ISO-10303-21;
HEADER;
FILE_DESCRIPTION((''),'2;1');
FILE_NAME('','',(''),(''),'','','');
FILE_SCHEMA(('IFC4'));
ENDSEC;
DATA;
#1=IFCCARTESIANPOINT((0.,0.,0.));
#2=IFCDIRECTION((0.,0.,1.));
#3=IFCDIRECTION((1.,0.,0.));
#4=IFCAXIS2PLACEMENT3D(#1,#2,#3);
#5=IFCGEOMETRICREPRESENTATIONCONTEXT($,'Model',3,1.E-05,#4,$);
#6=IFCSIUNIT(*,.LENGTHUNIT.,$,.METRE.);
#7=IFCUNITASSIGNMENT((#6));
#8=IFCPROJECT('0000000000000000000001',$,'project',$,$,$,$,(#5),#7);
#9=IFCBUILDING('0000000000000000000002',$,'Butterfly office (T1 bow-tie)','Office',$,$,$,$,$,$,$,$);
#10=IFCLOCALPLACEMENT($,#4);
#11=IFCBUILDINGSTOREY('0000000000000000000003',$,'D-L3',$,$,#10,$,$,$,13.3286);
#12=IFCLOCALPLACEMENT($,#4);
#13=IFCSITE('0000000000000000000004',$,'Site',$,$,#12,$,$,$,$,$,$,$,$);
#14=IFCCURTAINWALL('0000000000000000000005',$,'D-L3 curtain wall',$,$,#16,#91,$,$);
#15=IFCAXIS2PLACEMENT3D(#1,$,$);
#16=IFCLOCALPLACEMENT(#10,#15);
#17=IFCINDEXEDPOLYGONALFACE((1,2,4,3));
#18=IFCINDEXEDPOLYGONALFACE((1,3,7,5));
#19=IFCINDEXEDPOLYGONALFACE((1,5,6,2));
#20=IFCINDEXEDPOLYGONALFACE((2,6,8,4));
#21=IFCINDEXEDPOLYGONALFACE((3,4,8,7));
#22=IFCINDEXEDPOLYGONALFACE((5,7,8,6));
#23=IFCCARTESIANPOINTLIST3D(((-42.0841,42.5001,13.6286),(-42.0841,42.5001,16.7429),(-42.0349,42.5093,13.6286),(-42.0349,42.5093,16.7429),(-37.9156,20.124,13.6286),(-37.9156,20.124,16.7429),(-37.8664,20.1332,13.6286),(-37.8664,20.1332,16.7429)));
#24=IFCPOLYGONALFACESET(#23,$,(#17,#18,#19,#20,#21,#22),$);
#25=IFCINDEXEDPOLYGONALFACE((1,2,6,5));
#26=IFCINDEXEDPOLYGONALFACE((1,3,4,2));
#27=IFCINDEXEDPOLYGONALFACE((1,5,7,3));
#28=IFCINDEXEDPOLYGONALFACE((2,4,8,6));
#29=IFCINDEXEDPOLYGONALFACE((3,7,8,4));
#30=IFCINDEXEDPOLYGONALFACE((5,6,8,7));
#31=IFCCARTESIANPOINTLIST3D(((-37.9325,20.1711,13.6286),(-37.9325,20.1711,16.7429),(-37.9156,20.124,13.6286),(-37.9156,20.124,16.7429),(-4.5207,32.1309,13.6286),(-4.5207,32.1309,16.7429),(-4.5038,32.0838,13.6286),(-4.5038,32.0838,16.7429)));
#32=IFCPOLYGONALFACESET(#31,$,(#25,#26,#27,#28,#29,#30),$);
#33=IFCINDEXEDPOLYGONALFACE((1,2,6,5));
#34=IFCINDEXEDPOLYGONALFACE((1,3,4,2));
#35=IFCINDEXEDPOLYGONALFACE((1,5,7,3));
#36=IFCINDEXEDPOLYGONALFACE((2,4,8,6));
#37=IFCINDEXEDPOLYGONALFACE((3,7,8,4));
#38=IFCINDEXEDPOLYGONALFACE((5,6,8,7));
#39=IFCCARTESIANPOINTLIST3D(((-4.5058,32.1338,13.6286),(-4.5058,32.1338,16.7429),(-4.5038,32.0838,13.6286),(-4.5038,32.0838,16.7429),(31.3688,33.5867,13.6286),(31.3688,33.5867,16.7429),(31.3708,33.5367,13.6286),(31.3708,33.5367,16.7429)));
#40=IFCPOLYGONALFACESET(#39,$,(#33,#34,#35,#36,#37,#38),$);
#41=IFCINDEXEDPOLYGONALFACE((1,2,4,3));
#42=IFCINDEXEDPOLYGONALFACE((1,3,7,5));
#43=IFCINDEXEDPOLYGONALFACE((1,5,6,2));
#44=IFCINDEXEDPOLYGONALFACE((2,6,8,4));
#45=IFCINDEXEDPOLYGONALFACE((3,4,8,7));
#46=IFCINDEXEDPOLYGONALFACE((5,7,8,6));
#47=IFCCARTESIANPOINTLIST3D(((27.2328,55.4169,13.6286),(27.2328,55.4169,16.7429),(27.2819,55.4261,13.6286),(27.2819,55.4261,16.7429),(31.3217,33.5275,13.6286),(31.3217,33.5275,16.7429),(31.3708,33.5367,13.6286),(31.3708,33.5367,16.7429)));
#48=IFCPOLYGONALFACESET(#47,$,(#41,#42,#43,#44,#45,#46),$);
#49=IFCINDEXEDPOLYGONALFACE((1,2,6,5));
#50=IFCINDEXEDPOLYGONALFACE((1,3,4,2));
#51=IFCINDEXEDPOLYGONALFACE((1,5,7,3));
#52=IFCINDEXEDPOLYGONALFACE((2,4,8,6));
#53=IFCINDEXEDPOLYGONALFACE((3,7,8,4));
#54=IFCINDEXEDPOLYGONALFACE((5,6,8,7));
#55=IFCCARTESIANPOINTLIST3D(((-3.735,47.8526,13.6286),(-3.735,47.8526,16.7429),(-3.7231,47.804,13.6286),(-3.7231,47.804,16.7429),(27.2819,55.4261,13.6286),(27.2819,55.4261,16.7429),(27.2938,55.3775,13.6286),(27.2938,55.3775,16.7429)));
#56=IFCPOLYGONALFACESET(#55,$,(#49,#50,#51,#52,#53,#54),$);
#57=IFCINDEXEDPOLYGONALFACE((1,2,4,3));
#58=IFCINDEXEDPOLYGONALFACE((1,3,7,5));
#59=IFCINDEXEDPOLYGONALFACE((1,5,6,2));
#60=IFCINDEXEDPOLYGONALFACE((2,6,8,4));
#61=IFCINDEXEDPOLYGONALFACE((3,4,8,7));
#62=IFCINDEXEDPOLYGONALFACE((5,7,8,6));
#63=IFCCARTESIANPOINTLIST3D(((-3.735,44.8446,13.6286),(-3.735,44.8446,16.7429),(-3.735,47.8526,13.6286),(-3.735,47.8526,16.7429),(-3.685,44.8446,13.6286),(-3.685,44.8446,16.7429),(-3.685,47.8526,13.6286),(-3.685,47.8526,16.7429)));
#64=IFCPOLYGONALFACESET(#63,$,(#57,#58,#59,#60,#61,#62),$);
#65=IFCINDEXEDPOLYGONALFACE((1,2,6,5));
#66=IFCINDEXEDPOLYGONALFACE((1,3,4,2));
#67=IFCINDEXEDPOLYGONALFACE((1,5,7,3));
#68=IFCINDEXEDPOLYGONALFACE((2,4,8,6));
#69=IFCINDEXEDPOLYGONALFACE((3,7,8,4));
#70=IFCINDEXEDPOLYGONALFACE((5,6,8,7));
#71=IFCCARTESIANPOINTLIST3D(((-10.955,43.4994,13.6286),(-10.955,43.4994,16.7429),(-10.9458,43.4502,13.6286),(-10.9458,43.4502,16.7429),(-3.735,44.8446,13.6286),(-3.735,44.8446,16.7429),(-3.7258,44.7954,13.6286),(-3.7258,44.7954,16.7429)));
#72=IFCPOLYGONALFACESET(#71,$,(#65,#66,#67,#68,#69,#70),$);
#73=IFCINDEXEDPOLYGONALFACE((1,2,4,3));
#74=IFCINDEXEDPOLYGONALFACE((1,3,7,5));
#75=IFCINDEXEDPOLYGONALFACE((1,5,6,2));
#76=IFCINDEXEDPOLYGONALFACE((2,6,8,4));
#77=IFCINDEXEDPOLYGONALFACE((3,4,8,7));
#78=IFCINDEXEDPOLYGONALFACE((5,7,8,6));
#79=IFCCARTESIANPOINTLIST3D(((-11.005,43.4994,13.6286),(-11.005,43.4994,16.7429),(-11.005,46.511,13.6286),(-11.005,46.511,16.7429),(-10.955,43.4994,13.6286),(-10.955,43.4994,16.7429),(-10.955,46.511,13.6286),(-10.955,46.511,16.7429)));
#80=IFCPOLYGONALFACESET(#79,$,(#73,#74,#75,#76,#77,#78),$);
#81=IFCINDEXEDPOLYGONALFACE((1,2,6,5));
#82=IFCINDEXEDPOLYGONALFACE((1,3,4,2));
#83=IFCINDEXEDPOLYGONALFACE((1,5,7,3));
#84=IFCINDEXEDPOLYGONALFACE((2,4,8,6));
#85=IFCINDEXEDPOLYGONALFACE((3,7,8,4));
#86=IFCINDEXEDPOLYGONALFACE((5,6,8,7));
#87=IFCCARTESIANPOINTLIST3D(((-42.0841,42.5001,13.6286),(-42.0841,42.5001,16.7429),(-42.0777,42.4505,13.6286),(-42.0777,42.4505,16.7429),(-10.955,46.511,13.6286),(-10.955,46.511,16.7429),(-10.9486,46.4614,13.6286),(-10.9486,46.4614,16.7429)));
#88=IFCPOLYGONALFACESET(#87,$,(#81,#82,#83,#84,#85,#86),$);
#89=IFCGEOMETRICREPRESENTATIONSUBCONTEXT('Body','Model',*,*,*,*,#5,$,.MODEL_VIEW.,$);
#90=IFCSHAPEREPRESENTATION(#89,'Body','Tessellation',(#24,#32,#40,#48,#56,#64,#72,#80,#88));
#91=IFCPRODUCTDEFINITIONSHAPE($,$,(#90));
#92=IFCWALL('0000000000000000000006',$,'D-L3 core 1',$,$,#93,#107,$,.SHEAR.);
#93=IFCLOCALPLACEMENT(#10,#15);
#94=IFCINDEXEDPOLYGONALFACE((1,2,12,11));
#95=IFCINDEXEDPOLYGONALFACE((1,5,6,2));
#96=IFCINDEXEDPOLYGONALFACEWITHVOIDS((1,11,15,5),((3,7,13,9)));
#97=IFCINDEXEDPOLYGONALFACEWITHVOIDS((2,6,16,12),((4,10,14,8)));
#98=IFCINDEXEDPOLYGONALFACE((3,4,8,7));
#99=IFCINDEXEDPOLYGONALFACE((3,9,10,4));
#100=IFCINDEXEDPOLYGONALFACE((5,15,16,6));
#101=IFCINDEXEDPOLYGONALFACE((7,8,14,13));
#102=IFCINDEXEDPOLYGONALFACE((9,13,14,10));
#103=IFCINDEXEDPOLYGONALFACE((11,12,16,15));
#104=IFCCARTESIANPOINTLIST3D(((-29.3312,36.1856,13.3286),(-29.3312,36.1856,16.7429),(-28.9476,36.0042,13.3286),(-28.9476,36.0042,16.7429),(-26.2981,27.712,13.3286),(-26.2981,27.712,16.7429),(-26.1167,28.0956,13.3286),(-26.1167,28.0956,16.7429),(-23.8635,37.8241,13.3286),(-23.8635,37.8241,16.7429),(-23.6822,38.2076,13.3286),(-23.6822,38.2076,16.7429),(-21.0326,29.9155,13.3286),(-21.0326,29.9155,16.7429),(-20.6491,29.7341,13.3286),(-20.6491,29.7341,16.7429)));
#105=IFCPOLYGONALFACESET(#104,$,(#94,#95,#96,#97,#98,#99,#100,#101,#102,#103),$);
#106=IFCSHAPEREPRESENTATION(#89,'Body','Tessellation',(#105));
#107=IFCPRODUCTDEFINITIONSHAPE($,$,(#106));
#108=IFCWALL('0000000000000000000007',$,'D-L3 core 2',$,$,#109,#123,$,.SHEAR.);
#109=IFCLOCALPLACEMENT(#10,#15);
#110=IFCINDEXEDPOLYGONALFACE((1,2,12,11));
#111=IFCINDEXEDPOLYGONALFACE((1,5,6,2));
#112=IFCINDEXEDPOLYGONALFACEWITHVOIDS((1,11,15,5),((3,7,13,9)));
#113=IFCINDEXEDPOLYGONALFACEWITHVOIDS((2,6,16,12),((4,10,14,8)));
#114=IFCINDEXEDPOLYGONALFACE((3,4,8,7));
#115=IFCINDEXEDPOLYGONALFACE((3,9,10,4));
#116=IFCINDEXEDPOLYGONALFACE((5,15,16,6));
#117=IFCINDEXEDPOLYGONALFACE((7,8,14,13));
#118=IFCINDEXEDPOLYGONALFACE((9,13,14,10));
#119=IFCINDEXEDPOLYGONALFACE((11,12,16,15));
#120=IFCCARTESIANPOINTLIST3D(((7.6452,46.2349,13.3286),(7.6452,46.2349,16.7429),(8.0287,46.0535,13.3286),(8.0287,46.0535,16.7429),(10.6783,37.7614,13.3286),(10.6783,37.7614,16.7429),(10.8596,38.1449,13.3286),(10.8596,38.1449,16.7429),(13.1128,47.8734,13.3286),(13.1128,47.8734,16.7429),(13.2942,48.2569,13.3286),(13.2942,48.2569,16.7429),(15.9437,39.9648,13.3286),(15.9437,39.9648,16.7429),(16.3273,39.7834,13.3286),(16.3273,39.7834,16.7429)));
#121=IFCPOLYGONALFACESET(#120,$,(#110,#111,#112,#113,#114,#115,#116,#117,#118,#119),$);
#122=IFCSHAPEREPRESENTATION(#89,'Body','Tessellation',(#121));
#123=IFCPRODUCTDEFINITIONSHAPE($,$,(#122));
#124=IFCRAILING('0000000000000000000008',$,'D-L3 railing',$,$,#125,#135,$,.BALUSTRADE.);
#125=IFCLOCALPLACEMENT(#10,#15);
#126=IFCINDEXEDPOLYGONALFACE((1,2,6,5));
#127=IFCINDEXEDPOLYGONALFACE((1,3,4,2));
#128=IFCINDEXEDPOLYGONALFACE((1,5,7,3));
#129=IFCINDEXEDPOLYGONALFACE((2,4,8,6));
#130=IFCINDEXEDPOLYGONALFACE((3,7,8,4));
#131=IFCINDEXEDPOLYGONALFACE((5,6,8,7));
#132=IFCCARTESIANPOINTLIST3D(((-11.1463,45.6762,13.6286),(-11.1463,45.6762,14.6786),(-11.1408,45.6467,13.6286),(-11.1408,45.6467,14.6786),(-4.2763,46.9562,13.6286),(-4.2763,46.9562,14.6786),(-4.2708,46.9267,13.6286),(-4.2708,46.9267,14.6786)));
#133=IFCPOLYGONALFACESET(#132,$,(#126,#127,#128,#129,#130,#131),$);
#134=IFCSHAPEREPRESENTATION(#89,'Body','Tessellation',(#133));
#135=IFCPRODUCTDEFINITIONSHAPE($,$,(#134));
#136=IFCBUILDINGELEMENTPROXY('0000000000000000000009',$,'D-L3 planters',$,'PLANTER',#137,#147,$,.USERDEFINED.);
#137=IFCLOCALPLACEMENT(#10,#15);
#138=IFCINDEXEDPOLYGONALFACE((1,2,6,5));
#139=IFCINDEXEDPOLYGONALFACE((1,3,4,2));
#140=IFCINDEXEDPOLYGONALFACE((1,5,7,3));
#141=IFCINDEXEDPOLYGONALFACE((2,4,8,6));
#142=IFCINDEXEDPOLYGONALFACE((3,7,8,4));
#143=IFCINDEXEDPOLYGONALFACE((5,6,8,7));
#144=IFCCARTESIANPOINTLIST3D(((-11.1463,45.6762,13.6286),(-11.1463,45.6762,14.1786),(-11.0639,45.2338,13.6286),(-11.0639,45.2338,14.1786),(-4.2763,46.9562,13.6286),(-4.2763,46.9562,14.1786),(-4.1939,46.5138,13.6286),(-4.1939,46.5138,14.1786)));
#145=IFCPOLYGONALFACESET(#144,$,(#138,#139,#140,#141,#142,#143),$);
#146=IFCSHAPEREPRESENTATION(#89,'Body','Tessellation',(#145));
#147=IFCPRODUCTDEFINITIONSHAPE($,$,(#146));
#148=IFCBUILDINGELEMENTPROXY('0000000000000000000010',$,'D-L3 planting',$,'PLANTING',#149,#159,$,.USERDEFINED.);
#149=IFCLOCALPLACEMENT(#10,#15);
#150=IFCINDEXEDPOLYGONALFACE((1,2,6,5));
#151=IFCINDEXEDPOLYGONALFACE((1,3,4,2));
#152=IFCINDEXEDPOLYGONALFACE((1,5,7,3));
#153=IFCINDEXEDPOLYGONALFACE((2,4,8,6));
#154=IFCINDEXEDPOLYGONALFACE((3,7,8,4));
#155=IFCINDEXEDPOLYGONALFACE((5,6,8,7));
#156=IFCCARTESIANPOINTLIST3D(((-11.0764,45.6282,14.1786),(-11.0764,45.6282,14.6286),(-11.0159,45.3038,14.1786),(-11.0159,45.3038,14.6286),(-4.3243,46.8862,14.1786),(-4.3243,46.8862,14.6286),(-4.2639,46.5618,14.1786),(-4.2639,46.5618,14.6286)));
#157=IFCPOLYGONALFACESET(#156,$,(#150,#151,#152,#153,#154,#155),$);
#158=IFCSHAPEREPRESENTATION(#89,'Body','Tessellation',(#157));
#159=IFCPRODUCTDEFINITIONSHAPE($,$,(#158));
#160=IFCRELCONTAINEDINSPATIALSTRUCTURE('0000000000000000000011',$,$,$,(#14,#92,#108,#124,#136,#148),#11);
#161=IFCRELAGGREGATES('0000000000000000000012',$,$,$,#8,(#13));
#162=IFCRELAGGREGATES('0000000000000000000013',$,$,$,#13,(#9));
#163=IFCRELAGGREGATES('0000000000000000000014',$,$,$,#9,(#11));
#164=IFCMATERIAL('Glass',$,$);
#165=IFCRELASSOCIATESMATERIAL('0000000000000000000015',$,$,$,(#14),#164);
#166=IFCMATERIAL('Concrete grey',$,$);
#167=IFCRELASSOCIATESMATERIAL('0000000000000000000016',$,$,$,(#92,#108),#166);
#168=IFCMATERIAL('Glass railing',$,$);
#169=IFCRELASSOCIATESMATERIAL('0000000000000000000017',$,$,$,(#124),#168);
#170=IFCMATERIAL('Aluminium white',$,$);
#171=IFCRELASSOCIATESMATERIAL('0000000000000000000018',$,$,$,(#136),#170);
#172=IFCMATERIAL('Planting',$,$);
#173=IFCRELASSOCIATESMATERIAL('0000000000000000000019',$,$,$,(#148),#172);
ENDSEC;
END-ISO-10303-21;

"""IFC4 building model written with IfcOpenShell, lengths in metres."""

from ifc_helpers import new_model, si_unit, frame, origin_with_axes, place, context, subcontext, project, spatial, polyline, outline, extrude, material, element, save


model = new_model("IFC4")

# Units and contexts
model_context = context("Model", 3, precision=1e-05, world=origin_with_axes())
body_context = subcontext(model_context, "Body", "Model", "MODEL_VIEW")
ifc_project = project(units=[si_unit("LENGTHUNIT", "METRE")], contexts=[model_context])

# Site, building, storey
site_placement = place(None, origin_with_axes())
site = spatial("IfcSite", under=ifc_project, at=site_placement, Name="Site")
building = spatial("IfcBuilding", under=site, Name="Butterfly office (T1 bow-tie)", Description="Office")
storey_placement = place(None, origin_with_axes())
storey = spatial("IfcBuildingStorey", under=building, at=storey_placement, Name="D-L3", Elevation=13.3286)

# Shared definitions
ifc_material_1 = material(Name="Concrete grey")

# Shared definitions
ifc_material_2 = material(Name="Aluminium white")

# Curtain wall
ifc_material_3 = material(Name="Glass")
curtain_wall_placement = place(storey_placement, origin_with_axes())
element("IfcCurtainWall", 1, at=curtain_wall_placement, inside=storey, material=ifc_material_3, Name="D-L3 curtain wall", context=body_context, shape_type="SweptSolid", body=[
    extrude(outline(polyline([(-42.0841, 42.5001), (-37.9156, 20.124), (-37.8664, 20.1332), (-42.0349, 42.5093), (-42.0841, 42.5001)])), frame((0.0, 0.0, 13.6286), z_axis=(0.0, 0.0, 1.0), x_axis=(1.0, 0.0, 0.0)), (0.0, 0.0, 1.0), 3.1143),
    extrude(outline(polyline([(-37.9156, 20.124), (-4.5038, 32.0838), (-4.5207, 32.1309), (-37.9325, 20.1711), (-37.9156, 20.124)])), frame((0.0, 0.0, 13.6286), z_axis=(0.0, 0.0, 1.0), x_axis=(1.0, 0.0, 0.0)), (0.0, 0.0, 1.0), 3.1143),
    extrude(outline(polyline([(-4.5038, 32.0838), (31.3708, 33.5367), (31.3688, 33.5867), (-4.5058, 32.1338), (-4.5038, 32.0838)])), frame((0.0, 0.0, 13.6286), z_axis=(0.0, 0.0, 1.0), x_axis=(1.0, 0.0, 0.0)), (0.0, 0.0, 1.0), 3.1143),
    extrude(outline(polyline([(31.3708, 33.5367), (27.2819, 55.4261), (27.2328, 55.4169), (31.3217, 33.5275), (31.3708, 33.5367)])), frame((0.0, 0.0, 13.6286), z_axis=(0.0, 0.0, 1.0), x_axis=(1.0, 0.0, 0.0)), (0.0, 0.0, 1.0), 3.1143),
    extrude(outline(polyline([(27.2819, 55.4261), (-3.735, 47.8526), (-3.7231, 47.804), (27.2938, 55.3775), (27.2819, 55.4261)])), frame((0.0, 0.0, 13.6286), z_axis=(0.0, 0.0, 1.0), x_axis=(1.0, 0.0, 0.0)), (0.0, 0.0, 1.0), 3.1143),
    extrude(outline(polyline([(-3.735, 47.8526), (-3.735, 44.8446), (-3.685, 44.8446), (-3.685, 47.8526), (-3.735, 47.8526)])), frame((0.0, 0.0, 13.6286), z_axis=(0.0, 0.0, 1.0), x_axis=(1.0, 0.0, 0.0)), (0.0, 0.0, 1.0), 3.1143),
    extrude(outline(polyline([(-3.735, 44.8446), (-10.955, 43.4994), (-10.9458, 43.4502), (-3.7258, 44.7954), (-3.735, 44.8446)])), frame((0.0, 0.0, 13.6286), z_axis=(0.0, 0.0, 1.0), x_axis=(1.0, 0.0, 0.0)), (0.0, 0.0, 1.0), 3.1143),
    extrude(outline(polyline([(-10.955, 43.4994), (-10.955, 46.511), (-11.005, 46.511), (-11.005, 43.4994), (-10.955, 43.4994)])), frame((0.0, 0.0, 13.6286), z_axis=(0.0, 0.0, 1.0), x_axis=(1.0, 0.0, 0.0)), (0.0, 0.0, 1.0), 3.1143),
    extrude(outline(polyline([(-10.955, 46.511), (-42.0841, 42.5001), (-42.0777, 42.4505), (-10.9486, 46.4614), (-10.955, 46.511)])), frame((0.0, 0.0, 13.6286), z_axis=(0.0, 0.0, 1.0), x_axis=(1.0, 0.0, 0.0)), (0.0, 0.0, 1.0), 3.1143),
])

# Walls
wall_1_placement = place(storey_placement, origin_with_axes())
element("IfcWall", 2, at=wall_1_placement, inside=storey, material=ifc_material_1, Name="D-L3 core 1", PredefinedType="SHEAR", context=body_context, shape_type="SweptSolid", body=[
    extrude(outline(polyline([(-26.2981, 27.712), (-20.6491, 29.7341), (-23.6822, 38.2076), (-29.3312, 36.1856), (-26.2981, 27.712)]), holes=[polyline([(-26.1167, 28.0956), (-21.0326, 29.9155), (-23.8635, 37.8241), (-28.9476, 36.0042), (-26.1167, 28.0956)])]), frame((0.0, 0.0, 13.3286), z_axis=(0.0, 0.0, 1.0), x_axis=(1.0, 0.0, 0.0)), (0.0, 0.0, 1.0), 3.4143),
])
wall_2_placement = place(storey_placement, origin_with_axes())
element("IfcWall", 3, at=wall_2_placement, inside=storey, material=ifc_material_1, Name="D-L3 core 2", PredefinedType="SHEAR", context=body_context, shape_type="SweptSolid", body=[
    extrude(outline(polyline([(10.6783, 37.7614), (16.3273, 39.7834), (13.2942, 48.2569), (7.6452, 46.2349), (10.6783, 37.7614)]), holes=[polyline([(10.8596, 38.1449), (15.9437, 39.9648), (13.1128, 47.8734), (8.0287, 46.0535), (10.8596, 38.1449)])]), frame((0.0, 0.0, 13.3286), z_axis=(0.0, 0.0, 1.0), x_axis=(1.0, 0.0, 0.0)), (0.0, 0.0, 1.0), 3.4143),
])

# Railing
ifc_material_4 = material(Name="Glass railing")
railing_placement = place(storey_placement, origin_with_axes())
element("IfcRailing", 4, at=railing_placement, inside=storey, material=ifc_material_4, Name="D-L3 railing", PredefinedType="BALUSTRADE", context=body_context, shape_type="SweptSolid", body=[
    extrude(outline(polyline([(-4.2763, 46.9562), (-11.1463, 45.6762), (-11.1408, 45.6467), (-4.2708, 46.9267), (-4.2763, 46.9562)])), frame((0.0, 0.0, 13.6286), z_axis=(0.0, 0.0, 1.0), x_axis=(1.0, 0.0, 0.0)), (0.0, 0.0, 1.0), 1.05),
])

# Building element proxies
proxy_1_placement = place(storey_placement, origin_with_axes())
element("IfcBuildingElementProxy", 5, at=proxy_1_placement, inside=storey, material=ifc_material_2, Name="D-L3 planters", ObjectType="PLANTER", PredefinedType="USERDEFINED", context=body_context, shape_type="SweptSolid", body=[
    extrude(outline(polyline([(-4.2763, 46.9562), (-11.1463, 45.6762), (-11.0639, 45.2338), (-4.1939, 46.5138), (-4.2763, 46.9562)])), frame((0.0, 0.0, 13.6286), z_axis=(0.0, 0.0, 1.0), x_axis=(1.0, 0.0, 0.0)), (0.0, 0.0, 1.0), 0.55),
])
ifc_material_5 = material(Name="Planting")
proxy_2_placement = place(storey_placement, origin_with_axes())
element("IfcBuildingElementProxy", 6, at=proxy_2_placement, inside=storey, material=ifc_material_5, Name="D-L3 planting", ObjectType="PLANTING", PredefinedType="USERDEFINED", context=body_context, shape_type="SweptSolid", body=[
    extrude(outline(polyline([(-4.3243, 46.8862), (-11.0764, 45.6282), (-11.0159, 45.3038), (-4.2639, 46.5618), (-4.3243, 46.8862)])), frame((0.0, 0.0, 14.1786), z_axis=(0.0, 0.0, 1.0), x_axis=(1.0, 0.0, 0.0)), (0.0, 0.0, 1.0), 0.45),
])

save(model, "model.ifc")
